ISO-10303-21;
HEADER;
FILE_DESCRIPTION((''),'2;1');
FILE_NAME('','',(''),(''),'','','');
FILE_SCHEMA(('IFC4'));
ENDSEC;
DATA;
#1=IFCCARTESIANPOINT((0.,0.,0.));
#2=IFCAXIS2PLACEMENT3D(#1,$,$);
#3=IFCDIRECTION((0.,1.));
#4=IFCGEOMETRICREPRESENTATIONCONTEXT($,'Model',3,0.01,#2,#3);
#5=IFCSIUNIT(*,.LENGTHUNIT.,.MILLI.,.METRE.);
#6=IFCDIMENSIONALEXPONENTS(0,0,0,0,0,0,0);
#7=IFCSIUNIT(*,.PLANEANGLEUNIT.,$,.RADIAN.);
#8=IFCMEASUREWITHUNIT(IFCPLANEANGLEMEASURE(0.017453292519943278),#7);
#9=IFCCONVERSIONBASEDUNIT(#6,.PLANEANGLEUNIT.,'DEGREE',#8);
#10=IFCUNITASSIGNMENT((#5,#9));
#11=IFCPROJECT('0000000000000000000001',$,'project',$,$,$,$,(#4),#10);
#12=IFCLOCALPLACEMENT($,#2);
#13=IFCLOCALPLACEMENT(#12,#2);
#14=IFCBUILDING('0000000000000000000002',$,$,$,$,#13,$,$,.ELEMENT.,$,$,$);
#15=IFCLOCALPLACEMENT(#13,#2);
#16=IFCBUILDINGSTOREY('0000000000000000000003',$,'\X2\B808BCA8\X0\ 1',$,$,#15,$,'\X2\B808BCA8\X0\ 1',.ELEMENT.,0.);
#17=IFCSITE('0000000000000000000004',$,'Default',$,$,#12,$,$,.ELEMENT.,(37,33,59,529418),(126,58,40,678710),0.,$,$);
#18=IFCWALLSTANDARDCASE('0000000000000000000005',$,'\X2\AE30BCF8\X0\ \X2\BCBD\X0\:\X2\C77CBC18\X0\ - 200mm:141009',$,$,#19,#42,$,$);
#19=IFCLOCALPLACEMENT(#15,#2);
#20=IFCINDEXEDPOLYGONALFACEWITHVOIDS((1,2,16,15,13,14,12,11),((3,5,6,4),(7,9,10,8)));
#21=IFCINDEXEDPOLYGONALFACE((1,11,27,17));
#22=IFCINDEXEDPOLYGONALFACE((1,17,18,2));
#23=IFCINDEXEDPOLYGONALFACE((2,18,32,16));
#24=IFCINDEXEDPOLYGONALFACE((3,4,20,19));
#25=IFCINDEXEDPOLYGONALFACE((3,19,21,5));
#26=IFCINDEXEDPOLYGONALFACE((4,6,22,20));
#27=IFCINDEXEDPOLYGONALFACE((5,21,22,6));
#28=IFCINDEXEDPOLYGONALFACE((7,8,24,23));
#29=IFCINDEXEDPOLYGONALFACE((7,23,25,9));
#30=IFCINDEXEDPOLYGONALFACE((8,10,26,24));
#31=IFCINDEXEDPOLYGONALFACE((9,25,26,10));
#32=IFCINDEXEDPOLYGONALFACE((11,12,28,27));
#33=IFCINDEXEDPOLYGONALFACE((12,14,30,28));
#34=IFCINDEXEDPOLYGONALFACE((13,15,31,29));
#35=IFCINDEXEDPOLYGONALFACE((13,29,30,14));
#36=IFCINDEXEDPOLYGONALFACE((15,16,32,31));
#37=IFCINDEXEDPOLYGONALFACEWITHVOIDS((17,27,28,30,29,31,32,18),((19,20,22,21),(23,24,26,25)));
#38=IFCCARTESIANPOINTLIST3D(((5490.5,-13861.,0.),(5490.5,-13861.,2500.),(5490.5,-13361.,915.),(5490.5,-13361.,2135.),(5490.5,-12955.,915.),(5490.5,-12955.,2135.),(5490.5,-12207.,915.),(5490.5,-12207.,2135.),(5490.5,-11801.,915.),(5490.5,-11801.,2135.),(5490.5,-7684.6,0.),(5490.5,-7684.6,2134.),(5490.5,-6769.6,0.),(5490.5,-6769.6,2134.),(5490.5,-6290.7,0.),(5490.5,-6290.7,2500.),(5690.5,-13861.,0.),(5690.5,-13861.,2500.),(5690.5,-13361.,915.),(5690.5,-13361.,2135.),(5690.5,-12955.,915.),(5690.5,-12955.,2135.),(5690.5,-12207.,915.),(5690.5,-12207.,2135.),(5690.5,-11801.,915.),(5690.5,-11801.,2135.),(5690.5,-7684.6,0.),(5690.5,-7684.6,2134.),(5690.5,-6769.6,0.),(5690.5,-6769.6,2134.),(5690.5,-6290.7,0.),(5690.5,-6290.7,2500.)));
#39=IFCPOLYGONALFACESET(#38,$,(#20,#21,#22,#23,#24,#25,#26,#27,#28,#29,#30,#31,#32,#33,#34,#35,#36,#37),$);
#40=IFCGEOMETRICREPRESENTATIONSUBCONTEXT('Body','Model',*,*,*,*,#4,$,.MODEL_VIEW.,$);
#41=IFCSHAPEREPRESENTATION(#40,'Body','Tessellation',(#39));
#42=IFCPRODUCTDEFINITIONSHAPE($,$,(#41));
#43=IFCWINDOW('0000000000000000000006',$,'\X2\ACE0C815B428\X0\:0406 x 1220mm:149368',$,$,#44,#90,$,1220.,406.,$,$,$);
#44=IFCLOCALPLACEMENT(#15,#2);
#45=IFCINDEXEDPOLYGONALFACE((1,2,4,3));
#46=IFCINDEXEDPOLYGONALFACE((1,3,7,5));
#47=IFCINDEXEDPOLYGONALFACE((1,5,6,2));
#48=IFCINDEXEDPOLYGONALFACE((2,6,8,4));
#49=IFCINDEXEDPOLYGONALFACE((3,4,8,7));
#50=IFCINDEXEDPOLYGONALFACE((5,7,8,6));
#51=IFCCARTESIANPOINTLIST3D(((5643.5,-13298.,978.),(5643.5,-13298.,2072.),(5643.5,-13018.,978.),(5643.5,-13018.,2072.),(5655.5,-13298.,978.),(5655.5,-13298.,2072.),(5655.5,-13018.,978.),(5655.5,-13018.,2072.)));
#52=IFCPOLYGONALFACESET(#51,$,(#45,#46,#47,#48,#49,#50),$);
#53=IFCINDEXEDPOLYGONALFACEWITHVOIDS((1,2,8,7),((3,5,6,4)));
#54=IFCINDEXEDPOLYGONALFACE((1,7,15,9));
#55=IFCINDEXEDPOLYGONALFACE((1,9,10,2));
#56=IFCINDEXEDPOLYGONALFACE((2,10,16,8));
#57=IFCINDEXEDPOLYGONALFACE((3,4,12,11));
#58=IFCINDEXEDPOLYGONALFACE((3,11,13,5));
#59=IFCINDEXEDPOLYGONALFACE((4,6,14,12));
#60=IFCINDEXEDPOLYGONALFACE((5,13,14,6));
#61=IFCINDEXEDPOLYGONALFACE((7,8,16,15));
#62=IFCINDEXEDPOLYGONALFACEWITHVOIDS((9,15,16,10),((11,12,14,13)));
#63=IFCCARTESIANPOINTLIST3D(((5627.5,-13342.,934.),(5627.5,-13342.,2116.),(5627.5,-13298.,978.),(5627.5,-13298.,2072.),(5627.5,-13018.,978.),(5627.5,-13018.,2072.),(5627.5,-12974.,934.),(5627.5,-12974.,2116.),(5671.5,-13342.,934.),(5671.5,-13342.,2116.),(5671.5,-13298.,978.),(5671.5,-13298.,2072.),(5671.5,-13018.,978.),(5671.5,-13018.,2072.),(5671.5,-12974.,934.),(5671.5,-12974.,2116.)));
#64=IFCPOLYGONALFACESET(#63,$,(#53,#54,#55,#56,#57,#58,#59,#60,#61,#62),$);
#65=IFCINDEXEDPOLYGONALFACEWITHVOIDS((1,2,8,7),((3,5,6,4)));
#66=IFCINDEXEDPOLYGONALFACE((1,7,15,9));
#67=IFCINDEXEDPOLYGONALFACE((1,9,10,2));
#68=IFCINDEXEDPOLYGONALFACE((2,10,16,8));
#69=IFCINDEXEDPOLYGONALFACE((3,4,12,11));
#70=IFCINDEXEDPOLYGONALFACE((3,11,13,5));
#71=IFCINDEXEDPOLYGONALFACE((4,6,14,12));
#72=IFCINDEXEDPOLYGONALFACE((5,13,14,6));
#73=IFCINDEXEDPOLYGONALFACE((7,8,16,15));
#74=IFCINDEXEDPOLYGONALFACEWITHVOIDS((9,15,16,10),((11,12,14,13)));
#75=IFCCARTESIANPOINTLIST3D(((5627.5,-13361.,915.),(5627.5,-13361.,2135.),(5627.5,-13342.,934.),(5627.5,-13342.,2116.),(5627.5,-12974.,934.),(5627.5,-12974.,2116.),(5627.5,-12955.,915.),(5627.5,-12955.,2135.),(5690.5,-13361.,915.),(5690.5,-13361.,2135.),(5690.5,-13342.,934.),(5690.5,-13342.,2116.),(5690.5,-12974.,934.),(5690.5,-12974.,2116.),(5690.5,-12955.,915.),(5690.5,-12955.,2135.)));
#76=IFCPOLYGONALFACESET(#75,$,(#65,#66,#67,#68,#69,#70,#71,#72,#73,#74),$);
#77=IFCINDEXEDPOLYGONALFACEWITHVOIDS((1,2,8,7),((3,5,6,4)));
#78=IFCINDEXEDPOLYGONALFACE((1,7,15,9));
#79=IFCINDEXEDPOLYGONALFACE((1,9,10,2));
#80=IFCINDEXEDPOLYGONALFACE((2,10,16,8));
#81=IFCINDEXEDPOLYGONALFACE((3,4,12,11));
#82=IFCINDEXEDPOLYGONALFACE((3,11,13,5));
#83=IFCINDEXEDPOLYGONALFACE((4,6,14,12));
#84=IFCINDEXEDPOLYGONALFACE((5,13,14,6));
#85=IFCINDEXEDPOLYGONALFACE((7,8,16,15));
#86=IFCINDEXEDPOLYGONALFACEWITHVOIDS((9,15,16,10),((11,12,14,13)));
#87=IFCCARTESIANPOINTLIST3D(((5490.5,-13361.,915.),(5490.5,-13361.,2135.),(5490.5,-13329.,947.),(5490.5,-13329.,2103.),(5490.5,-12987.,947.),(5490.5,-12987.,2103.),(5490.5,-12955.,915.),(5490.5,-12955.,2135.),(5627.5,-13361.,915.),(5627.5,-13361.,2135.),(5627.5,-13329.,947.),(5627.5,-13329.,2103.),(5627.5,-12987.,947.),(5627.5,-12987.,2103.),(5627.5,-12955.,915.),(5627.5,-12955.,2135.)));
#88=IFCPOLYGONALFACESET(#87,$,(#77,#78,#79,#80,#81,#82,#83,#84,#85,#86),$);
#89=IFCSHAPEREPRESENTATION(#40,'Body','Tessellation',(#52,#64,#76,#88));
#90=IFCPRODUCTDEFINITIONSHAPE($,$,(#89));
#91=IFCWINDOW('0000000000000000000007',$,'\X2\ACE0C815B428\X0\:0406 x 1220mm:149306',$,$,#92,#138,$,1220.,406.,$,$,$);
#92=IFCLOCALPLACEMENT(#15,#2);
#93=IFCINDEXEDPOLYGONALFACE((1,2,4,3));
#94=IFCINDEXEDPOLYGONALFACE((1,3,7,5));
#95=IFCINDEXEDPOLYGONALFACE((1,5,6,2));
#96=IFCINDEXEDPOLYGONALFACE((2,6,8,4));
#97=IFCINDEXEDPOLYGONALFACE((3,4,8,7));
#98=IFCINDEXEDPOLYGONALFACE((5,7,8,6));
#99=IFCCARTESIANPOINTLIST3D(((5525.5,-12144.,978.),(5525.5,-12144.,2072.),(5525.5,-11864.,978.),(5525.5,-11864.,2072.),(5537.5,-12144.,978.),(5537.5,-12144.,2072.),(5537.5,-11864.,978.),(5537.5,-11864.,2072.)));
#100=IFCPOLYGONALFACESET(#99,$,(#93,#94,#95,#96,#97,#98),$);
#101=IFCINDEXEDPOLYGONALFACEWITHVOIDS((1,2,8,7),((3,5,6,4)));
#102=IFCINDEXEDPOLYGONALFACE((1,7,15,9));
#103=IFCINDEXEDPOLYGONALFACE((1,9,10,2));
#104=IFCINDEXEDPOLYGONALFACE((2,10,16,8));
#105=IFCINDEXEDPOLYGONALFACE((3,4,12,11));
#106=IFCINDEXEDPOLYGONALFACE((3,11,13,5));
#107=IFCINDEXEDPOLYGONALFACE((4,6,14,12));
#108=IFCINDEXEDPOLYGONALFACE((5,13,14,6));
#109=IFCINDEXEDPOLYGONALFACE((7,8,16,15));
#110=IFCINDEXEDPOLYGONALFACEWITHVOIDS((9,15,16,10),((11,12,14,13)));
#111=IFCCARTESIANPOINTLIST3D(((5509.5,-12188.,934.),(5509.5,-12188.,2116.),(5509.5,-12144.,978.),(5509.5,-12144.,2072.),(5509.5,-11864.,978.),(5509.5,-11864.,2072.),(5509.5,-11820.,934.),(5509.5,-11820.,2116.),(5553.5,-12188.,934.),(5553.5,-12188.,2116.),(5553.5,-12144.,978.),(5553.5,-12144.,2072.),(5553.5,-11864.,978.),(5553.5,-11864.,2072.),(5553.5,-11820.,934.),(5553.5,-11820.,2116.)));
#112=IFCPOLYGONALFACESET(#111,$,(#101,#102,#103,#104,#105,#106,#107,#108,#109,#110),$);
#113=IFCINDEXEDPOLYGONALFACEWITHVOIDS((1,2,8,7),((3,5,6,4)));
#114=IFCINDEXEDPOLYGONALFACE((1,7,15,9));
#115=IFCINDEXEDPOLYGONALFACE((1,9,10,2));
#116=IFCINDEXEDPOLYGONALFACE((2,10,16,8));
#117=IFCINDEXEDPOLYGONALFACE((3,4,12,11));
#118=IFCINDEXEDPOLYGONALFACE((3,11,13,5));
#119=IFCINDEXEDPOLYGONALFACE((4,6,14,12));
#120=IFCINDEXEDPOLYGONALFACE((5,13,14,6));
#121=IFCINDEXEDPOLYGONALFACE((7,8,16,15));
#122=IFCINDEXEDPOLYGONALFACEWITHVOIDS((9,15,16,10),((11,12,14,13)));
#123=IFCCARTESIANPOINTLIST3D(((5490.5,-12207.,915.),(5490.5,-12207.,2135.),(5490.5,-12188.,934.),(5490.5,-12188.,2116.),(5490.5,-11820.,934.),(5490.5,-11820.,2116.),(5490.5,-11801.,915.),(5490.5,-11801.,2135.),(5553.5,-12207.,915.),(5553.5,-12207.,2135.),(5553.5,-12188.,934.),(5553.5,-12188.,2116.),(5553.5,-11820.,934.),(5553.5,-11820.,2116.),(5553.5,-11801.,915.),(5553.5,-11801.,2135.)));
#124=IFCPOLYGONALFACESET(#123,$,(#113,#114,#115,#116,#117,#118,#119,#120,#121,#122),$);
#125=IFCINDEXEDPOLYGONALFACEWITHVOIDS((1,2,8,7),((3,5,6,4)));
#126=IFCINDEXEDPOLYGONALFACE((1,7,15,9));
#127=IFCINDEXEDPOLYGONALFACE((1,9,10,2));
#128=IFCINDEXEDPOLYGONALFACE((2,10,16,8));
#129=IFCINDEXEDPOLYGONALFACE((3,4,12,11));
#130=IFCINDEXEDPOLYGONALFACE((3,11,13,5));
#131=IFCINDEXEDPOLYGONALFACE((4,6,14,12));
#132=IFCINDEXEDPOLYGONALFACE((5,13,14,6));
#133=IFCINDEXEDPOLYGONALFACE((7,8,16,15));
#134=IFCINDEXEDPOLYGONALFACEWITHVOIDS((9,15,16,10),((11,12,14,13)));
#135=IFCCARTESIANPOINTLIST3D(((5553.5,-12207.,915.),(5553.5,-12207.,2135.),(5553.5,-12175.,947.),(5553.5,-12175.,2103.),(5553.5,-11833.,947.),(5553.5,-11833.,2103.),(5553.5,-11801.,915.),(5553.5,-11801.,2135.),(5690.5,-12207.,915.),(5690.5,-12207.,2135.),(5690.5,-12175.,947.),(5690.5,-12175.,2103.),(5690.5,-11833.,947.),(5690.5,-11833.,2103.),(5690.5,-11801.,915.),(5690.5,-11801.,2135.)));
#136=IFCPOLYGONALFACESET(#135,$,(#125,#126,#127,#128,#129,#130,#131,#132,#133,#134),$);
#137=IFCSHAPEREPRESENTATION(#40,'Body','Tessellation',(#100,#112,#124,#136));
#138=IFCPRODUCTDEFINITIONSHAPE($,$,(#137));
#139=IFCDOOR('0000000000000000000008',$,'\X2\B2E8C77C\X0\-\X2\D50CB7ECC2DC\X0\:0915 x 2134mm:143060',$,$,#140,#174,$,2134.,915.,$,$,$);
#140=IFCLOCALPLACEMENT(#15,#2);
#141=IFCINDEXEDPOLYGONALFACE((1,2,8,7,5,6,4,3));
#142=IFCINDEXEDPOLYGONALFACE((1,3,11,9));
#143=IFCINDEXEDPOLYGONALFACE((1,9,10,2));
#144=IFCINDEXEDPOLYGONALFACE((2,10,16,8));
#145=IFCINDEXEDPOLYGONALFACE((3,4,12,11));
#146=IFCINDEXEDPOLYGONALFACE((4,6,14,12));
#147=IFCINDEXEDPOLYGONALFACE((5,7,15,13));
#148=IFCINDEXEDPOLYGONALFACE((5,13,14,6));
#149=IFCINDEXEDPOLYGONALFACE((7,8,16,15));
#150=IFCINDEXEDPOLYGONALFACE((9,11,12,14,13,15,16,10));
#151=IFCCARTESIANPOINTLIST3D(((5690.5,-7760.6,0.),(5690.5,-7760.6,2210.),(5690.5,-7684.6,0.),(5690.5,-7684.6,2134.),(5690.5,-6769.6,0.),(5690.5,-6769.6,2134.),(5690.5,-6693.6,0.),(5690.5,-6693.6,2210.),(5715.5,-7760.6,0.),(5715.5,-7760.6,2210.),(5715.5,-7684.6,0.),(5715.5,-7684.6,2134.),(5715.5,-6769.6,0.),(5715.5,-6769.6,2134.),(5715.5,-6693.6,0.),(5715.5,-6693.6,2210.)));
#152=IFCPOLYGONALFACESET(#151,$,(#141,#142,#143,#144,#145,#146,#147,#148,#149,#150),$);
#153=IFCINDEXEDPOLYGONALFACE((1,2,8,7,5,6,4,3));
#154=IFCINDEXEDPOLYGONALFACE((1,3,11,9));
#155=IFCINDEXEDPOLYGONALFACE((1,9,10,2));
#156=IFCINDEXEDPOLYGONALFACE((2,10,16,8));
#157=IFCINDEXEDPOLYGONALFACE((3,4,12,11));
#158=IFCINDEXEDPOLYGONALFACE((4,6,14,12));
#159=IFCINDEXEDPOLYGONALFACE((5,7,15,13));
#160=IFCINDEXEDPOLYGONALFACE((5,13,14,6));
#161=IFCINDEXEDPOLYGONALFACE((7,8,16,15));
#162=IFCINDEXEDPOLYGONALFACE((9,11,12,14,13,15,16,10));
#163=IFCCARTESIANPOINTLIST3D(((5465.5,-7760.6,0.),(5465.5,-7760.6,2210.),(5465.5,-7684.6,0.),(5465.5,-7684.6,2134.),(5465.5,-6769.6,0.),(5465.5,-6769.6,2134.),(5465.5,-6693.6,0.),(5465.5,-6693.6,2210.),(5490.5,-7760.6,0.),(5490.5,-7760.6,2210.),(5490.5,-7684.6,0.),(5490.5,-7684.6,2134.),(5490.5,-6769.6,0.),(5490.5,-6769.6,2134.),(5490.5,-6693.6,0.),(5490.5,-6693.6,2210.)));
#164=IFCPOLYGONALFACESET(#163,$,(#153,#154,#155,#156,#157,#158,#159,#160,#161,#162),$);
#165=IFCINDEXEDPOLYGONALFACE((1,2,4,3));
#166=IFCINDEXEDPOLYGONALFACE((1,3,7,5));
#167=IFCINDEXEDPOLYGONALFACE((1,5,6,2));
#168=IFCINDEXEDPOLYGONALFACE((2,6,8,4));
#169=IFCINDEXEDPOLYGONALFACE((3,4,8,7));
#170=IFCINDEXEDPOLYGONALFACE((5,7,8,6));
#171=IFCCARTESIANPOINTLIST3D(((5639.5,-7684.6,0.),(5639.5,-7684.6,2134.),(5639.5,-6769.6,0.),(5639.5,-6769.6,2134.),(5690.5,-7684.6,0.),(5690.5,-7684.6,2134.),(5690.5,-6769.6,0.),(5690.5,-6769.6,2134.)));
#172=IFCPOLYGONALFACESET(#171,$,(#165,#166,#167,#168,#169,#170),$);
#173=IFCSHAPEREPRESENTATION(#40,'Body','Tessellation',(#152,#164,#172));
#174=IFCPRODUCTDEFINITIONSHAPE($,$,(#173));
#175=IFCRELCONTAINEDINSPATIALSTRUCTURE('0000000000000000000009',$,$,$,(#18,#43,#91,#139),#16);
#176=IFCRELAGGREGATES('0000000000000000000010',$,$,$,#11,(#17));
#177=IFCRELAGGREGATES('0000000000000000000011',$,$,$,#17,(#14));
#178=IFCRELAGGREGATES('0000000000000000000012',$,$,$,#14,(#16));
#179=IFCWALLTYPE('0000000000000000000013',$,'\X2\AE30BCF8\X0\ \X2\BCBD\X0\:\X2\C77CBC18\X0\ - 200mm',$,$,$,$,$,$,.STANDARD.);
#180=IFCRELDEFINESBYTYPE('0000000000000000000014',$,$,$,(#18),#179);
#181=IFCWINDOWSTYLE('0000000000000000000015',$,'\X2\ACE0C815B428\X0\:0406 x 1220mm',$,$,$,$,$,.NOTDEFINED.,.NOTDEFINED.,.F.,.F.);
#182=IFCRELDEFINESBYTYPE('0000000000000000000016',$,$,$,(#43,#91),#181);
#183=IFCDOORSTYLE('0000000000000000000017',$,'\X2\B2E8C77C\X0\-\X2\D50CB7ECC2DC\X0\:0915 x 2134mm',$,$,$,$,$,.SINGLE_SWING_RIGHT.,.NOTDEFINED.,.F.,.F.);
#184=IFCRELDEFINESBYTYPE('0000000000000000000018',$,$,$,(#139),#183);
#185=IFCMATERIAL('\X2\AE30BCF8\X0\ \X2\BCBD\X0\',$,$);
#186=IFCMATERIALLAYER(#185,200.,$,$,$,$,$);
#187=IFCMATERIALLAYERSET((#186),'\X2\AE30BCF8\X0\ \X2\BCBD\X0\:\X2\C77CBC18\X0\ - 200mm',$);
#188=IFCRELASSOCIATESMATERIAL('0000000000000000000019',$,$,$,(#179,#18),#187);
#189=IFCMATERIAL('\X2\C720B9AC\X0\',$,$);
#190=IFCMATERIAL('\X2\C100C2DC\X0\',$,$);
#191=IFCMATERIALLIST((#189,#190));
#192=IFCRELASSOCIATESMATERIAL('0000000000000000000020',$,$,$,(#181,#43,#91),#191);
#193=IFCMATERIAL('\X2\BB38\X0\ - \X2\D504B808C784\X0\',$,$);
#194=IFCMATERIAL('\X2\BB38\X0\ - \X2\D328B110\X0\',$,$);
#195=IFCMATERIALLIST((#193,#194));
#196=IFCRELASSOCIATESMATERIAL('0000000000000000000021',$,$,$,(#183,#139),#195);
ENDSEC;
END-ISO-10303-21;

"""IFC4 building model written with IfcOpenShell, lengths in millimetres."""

from ifc_helpers import new_model, entity, si_unit, converted_unit, direction, frame, frame_2d, origin, place, context, subcontext, project, spatial, polyline, rectangle, outline, extrude, source, transform, mapped, material, material_list, layer, layer_set, layer_usage, type_object, type_shapes, element, fill, save


model = new_model("IFC4")

# Units and contexts
model_context = context("Model", 3, precision=0.01, world=origin(), true_north=direction((0.0, 1.0)))
body_context = subcontext(model_context, "Body", "Model", "MODEL_VIEW")
ifc_project = project(units=[si_unit("LENGTHUNIT", "METRE", prefix="MILLI"), converted_unit("PLANEANGLEUNIT", "DEGREE", entity("IfcPlaneAngleMeasure", 0.017453292519943278), si_unit("PLANEANGLEUNIT", "RADIAN"), dimensions=[0, 0, 0, 0, 0, 0, 0])], contexts=[model_context])

# Site, building, storey
site_placement = place(None, origin())
site = spatial("IfcSite", under=ifc_project, at=site_placement, Name="Default", CompositionType="ELEMENT", RefLatitude=(37, 33, 59, 529418), RefLongitude=(126, 58, 40, 678710), RefElevation=0.0)
building_placement = place(site_placement, origin())
building = spatial("IfcBuilding", under=site, at=building_placement, CompositionType="ELEMENT")
storey_placement = place(building_placement, origin())
storey = spatial("IfcBuildingStorey", under=building, at=storey_placement, Name="레벨 1", LongName="레벨 1", CompositionType="ELEMENT", Elevation=0.0)

# Shared definitions
ifc_material_1 = material(Name="기본 벽")
ifc_layer = layer(ifc_material_1, 200.0)
ifc_layer_set = layer_set([ifc_layer], Name="기본 벽:일반 - 200mm")
wall_type = type_object("IfcWallType", Name="기본 벽:일반 - 200mm", PredefinedType="STANDARD", material=ifc_layer_set)
ifc_material_2 = material(Name="유리")
ifc_material_3 = material(Name="섀시")
ifc_material_list_1 = material_list([ifc_material_2, ifc_material_3])
window_style_1 = type_object("IfcWindowStyle", Name="고정됨:0406 x 1220mm", ConstructionType="NOTDEFINED", OperationType="NOTDEFINED", ParameterTakesPrecedence=False, Sizeable=False, material=ifc_material_list_1)
shared_shape_1 = source(origin(), body_context, "Body", "SweptSolid", [
    extrude(rectangle(XDim=12.0, YDim=280.0, at=frame_2d((0.0, 0.0), x_axis=(1.0, 0.0))), frame((203.0, 159.0, 63.0), z_axis=(0.0, 0.0, 1.0), x_axis=(0.0, -1.0, 0.0)), (0.0, 0.0, 1.0), 1094.0),
    extrude(outline(polyline([(-184.0, -591.0), (184.0, -591.0), (184.0, 591.0), (-184.0, 591.0), (-184.0, -591.0)]), holes=[polyline([(-140.0, -547.0), (-140.0, 547.0), (140.0, 547.0), (140.0, -547.0), (-140.0, -547.0)])]), frame((203.0, 137.0, 610.0), z_axis=(0.0, 1.0, 0.0), x_axis=(1.0, 0.0, 0.0)), (0.0, 0.0, 1.0), 44.0),
    extrude(outline(polyline([(-203.0, -610.0), (203.0, -610.0), (203.0, 610.0), (-203.0, 610.0), (-203.0, -610.0)]), holes=[polyline([(-184.0, -591.0), (-184.0, 591.0), (184.0, 591.0), (184.0, -591.0), (-184.0, -591.0)])]), frame((203.0, 137.0, 610.0), z_axis=(0.0, 1.0, 0.0), x_axis=(1.0, 0.0, 0.0)), (0.0, 0.0, 1.0), 63.0),
    extrude(outline(polyline([(-203.0, -610.0), (203.0, -610.0), (203.0, 610.0), (-203.0, 610.0), (-203.0, -610.0)]), holes=[polyline([(-171.0, -578.0), (-171.0, 578.0), (171.0, 578.0), (171.0, -578.0), (-171.0, -578.0)])]), frame((203.0, 0.0, 610.0), z_axis=(0.0, 1.0, 0.0), x_axis=(1.0, 0.0, 0.0)), (0.0, 0.0, 1.0), 137.0),
])
type_shapes(window_style_1, [shared_shape_1])

# Shared definitions
ifc_material_4 = material(Name="문 - 프레임")
ifc_material_5 = material(Name="문 - 패널")
ifc_material_list_2 = material_list([ifc_material_4, ifc_material_5])
door_style_1 = type_object("IfcDoorStyle", Name="단일-플러시:0915 x 2134mm", ConstructionType="NOTDEFINED", OperationType="SINGLE_SWING_RIGHT", ParameterTakesPrecedence=False, Sizeable=False, material=ifc_material_list_2)
shared_shape_2 = source(origin(), body_context, "Body", "SweptSolid", [
    extrude(outline(polyline([(-533.5, -1124.0), (533.5, -1124.0), (533.5, 1086.0), (457.5, 1086.0), (457.5, -1048.0), (-457.5, -1048.0), (-457.5, 1086.0), (-533.5, 1086.0), (-533.5, -1124.0)])), frame((457.5, 200.0, 1086.0), z_axis=(0.0, 1.0, 0.0), x_axis=(1.0, 0.0, 0.0)), (0.0, 0.0, 1.0), 25.0),
    extrude(outline(polyline([(-1124.0, -533.5), (1086.0, -533.5), (1086.0, -457.5), (-1048.0, -457.5), (-1048.0, 457.5), (1086.0, 457.5), (1086.0, 533.5), (-1124.0, 533.5), (-1124.0, -533.5)])), frame((457.5, -25.0, 1086.0), z_axis=(0.0, 1.0, 0.0), x_axis=(0.0, 0.0, -1.0)), (0.0, 0.0, 1.0), 25.0),
    extrude(rectangle(XDim=51.0, YDim=915.0, at=frame_2d((0.0, 0.0), x_axis=(1.0, 0.0))), frame((457.5, 174.5, 0.0), z_axis=(0.0, 0.0, 1.0), x_axis=(0.0, 1.0, 0.0)), (0.0, 0.0, 1.0), 2134.0),
])
type_shapes(door_style_1, [shared_shape_2])

# Wall, openings, windows, door
ifc_layer_usage_1 = layer_usage(ifc_layer_set, "AXIS2", "NEGATIVE", 100.0)
wall_1_placement = place(storey_placement, frame((5590.5, -6290.7, 0.0), z_axis=(0.0, 0.0, 1.0), x_axis=(0.0, -1.0, 0.0)))
wall_1 = element("IfcWallStandardCase", 1, at=wall_1_placement, inside=storey, type_object=wall_type, material=ifc_layer_usage_1, Name="기본 벽:일반 - 200mm:141009", context=body_context, shape_type="SweptSolid", body=[
    extrude(rectangle(XDim=7570.2, YDim=200.0, at=frame_2d((3785.1, 0.0), x_axis=(-1.0, 0.0))), origin(), (0.0, 0.0, 1.0), 2500.0),
])
opening_1_placement = place(wall_1_placement, frame((478.9, -100.0, 0.0)))
opening_1 = element("IfcOpeningElement", 2, at=opening_1_placement, cuts=wall_1, ObjectType="Opening", context=body_context, shape_type="SweptSolid", body=[
    extrude(rectangle(XDim=915.0, YDim=2134.0, at=frame_2d((1067.0, 457.5), x_axis=(0.0, 1.0))), frame((0.0, 0.0, 0.0), z_axis=(0.0, 1.0, 0.0), x_axis=(0.0, 0.0, 1.0)), (0.0, 0.0, 1.0), 200.0),
])
opening_2_placement = place(wall_1_placement, frame((6664.2, -100.0, 915.0)))
opening_2 = element("IfcOpeningElement", 3, at=opening_2_placement, cuts=wall_1, ObjectType="Opening", context=body_context, shape_type="SweptSolid", body=[
    extrude(rectangle(XDim=1220.0, YDim=406.0, at=frame_2d((610.0, 203.0), x_axis=(1.0, 0.0))), frame((0.0, 0.0, 0.0), z_axis=(0.0, 1.0, 0.0), x_axis=(0.0, 0.0, 1.0)), (0.0, 0.0, 1.0), 200.0),
])
opening_3_placement = place(wall_1_placement, frame((5916.2, 100.0, 915.0)))
opening_3 = element("IfcOpeningElement", 4, at=opening_3_placement, cuts=wall_1, ObjectType="Opening", context=body_context, shape_type="SweptSolid", body=[
    extrude(rectangle(XDim=1220.0, YDim=406.0, at=frame_2d((610.0, 203.0), x_axis=(1.0, 0.0))), frame((0.0, 0.0, 0.0), z_axis=(0.0, -1.0, 0.0), x_axis=(0.0, 0.0, 1.0)), (0.0, 0.0, 1.0), 200.0),
])
window_1_placement = place(opening_2_placement, origin())
window_1 = element("IfcWindow", 5, at=window_1_placement, inside=storey, type_object=window_style_1, material=ifc_material_list_1, Name="고정됨:0406 x 1220mm:149368", OverallHeight=1220.0, OverallWidth=406.0, context=body_context, shape_type="MappedRepresentation", body=[
    mapped(shared_shape_1, transform((0.0, 0.0, 0.0), scale=1.0)),
])
fill(opening_2, window_1)
window_2_placement = place(opening_3_placement, frame((0.0, 0.0, 0.0), z_axis=(0.0, 0.0, 1.0), x_axis=(-1.0, 0.0, 0.0)))
window_2 = element("IfcWindow", 6, at=window_2_placement, inside=storey, type_object=window_style_1, material=ifc_material_list_1, Name="고정됨:0406 x 1220mm:149306", OverallHeight=1220.0, OverallWidth=406.0, context=body_context, shape_type="MappedRepresentation", body=[
    mapped(shared_shape_1, transform((0.0, 0.0, 0.0), scale=1.0)),
])
fill(opening_3, window_2)
door_1_placement = place(opening_1_placement, origin())
door_1 = element("IfcDoor", 7, at=door_1_placement, inside=storey, type_object=door_style_1, material=ifc_material_list_2, Name="단일-플러시:0915 x 2134mm:143060", OverallHeight=2134.0, OverallWidth=915.0, context=body_context, shape_type="MappedRepresentation", body=[
    mapped(shared_shape_2, transform((0.0, 0.0, 0.0), scale=1.0)),
])
fill(opening_1, door_1)

save(model, "model.ifc")
